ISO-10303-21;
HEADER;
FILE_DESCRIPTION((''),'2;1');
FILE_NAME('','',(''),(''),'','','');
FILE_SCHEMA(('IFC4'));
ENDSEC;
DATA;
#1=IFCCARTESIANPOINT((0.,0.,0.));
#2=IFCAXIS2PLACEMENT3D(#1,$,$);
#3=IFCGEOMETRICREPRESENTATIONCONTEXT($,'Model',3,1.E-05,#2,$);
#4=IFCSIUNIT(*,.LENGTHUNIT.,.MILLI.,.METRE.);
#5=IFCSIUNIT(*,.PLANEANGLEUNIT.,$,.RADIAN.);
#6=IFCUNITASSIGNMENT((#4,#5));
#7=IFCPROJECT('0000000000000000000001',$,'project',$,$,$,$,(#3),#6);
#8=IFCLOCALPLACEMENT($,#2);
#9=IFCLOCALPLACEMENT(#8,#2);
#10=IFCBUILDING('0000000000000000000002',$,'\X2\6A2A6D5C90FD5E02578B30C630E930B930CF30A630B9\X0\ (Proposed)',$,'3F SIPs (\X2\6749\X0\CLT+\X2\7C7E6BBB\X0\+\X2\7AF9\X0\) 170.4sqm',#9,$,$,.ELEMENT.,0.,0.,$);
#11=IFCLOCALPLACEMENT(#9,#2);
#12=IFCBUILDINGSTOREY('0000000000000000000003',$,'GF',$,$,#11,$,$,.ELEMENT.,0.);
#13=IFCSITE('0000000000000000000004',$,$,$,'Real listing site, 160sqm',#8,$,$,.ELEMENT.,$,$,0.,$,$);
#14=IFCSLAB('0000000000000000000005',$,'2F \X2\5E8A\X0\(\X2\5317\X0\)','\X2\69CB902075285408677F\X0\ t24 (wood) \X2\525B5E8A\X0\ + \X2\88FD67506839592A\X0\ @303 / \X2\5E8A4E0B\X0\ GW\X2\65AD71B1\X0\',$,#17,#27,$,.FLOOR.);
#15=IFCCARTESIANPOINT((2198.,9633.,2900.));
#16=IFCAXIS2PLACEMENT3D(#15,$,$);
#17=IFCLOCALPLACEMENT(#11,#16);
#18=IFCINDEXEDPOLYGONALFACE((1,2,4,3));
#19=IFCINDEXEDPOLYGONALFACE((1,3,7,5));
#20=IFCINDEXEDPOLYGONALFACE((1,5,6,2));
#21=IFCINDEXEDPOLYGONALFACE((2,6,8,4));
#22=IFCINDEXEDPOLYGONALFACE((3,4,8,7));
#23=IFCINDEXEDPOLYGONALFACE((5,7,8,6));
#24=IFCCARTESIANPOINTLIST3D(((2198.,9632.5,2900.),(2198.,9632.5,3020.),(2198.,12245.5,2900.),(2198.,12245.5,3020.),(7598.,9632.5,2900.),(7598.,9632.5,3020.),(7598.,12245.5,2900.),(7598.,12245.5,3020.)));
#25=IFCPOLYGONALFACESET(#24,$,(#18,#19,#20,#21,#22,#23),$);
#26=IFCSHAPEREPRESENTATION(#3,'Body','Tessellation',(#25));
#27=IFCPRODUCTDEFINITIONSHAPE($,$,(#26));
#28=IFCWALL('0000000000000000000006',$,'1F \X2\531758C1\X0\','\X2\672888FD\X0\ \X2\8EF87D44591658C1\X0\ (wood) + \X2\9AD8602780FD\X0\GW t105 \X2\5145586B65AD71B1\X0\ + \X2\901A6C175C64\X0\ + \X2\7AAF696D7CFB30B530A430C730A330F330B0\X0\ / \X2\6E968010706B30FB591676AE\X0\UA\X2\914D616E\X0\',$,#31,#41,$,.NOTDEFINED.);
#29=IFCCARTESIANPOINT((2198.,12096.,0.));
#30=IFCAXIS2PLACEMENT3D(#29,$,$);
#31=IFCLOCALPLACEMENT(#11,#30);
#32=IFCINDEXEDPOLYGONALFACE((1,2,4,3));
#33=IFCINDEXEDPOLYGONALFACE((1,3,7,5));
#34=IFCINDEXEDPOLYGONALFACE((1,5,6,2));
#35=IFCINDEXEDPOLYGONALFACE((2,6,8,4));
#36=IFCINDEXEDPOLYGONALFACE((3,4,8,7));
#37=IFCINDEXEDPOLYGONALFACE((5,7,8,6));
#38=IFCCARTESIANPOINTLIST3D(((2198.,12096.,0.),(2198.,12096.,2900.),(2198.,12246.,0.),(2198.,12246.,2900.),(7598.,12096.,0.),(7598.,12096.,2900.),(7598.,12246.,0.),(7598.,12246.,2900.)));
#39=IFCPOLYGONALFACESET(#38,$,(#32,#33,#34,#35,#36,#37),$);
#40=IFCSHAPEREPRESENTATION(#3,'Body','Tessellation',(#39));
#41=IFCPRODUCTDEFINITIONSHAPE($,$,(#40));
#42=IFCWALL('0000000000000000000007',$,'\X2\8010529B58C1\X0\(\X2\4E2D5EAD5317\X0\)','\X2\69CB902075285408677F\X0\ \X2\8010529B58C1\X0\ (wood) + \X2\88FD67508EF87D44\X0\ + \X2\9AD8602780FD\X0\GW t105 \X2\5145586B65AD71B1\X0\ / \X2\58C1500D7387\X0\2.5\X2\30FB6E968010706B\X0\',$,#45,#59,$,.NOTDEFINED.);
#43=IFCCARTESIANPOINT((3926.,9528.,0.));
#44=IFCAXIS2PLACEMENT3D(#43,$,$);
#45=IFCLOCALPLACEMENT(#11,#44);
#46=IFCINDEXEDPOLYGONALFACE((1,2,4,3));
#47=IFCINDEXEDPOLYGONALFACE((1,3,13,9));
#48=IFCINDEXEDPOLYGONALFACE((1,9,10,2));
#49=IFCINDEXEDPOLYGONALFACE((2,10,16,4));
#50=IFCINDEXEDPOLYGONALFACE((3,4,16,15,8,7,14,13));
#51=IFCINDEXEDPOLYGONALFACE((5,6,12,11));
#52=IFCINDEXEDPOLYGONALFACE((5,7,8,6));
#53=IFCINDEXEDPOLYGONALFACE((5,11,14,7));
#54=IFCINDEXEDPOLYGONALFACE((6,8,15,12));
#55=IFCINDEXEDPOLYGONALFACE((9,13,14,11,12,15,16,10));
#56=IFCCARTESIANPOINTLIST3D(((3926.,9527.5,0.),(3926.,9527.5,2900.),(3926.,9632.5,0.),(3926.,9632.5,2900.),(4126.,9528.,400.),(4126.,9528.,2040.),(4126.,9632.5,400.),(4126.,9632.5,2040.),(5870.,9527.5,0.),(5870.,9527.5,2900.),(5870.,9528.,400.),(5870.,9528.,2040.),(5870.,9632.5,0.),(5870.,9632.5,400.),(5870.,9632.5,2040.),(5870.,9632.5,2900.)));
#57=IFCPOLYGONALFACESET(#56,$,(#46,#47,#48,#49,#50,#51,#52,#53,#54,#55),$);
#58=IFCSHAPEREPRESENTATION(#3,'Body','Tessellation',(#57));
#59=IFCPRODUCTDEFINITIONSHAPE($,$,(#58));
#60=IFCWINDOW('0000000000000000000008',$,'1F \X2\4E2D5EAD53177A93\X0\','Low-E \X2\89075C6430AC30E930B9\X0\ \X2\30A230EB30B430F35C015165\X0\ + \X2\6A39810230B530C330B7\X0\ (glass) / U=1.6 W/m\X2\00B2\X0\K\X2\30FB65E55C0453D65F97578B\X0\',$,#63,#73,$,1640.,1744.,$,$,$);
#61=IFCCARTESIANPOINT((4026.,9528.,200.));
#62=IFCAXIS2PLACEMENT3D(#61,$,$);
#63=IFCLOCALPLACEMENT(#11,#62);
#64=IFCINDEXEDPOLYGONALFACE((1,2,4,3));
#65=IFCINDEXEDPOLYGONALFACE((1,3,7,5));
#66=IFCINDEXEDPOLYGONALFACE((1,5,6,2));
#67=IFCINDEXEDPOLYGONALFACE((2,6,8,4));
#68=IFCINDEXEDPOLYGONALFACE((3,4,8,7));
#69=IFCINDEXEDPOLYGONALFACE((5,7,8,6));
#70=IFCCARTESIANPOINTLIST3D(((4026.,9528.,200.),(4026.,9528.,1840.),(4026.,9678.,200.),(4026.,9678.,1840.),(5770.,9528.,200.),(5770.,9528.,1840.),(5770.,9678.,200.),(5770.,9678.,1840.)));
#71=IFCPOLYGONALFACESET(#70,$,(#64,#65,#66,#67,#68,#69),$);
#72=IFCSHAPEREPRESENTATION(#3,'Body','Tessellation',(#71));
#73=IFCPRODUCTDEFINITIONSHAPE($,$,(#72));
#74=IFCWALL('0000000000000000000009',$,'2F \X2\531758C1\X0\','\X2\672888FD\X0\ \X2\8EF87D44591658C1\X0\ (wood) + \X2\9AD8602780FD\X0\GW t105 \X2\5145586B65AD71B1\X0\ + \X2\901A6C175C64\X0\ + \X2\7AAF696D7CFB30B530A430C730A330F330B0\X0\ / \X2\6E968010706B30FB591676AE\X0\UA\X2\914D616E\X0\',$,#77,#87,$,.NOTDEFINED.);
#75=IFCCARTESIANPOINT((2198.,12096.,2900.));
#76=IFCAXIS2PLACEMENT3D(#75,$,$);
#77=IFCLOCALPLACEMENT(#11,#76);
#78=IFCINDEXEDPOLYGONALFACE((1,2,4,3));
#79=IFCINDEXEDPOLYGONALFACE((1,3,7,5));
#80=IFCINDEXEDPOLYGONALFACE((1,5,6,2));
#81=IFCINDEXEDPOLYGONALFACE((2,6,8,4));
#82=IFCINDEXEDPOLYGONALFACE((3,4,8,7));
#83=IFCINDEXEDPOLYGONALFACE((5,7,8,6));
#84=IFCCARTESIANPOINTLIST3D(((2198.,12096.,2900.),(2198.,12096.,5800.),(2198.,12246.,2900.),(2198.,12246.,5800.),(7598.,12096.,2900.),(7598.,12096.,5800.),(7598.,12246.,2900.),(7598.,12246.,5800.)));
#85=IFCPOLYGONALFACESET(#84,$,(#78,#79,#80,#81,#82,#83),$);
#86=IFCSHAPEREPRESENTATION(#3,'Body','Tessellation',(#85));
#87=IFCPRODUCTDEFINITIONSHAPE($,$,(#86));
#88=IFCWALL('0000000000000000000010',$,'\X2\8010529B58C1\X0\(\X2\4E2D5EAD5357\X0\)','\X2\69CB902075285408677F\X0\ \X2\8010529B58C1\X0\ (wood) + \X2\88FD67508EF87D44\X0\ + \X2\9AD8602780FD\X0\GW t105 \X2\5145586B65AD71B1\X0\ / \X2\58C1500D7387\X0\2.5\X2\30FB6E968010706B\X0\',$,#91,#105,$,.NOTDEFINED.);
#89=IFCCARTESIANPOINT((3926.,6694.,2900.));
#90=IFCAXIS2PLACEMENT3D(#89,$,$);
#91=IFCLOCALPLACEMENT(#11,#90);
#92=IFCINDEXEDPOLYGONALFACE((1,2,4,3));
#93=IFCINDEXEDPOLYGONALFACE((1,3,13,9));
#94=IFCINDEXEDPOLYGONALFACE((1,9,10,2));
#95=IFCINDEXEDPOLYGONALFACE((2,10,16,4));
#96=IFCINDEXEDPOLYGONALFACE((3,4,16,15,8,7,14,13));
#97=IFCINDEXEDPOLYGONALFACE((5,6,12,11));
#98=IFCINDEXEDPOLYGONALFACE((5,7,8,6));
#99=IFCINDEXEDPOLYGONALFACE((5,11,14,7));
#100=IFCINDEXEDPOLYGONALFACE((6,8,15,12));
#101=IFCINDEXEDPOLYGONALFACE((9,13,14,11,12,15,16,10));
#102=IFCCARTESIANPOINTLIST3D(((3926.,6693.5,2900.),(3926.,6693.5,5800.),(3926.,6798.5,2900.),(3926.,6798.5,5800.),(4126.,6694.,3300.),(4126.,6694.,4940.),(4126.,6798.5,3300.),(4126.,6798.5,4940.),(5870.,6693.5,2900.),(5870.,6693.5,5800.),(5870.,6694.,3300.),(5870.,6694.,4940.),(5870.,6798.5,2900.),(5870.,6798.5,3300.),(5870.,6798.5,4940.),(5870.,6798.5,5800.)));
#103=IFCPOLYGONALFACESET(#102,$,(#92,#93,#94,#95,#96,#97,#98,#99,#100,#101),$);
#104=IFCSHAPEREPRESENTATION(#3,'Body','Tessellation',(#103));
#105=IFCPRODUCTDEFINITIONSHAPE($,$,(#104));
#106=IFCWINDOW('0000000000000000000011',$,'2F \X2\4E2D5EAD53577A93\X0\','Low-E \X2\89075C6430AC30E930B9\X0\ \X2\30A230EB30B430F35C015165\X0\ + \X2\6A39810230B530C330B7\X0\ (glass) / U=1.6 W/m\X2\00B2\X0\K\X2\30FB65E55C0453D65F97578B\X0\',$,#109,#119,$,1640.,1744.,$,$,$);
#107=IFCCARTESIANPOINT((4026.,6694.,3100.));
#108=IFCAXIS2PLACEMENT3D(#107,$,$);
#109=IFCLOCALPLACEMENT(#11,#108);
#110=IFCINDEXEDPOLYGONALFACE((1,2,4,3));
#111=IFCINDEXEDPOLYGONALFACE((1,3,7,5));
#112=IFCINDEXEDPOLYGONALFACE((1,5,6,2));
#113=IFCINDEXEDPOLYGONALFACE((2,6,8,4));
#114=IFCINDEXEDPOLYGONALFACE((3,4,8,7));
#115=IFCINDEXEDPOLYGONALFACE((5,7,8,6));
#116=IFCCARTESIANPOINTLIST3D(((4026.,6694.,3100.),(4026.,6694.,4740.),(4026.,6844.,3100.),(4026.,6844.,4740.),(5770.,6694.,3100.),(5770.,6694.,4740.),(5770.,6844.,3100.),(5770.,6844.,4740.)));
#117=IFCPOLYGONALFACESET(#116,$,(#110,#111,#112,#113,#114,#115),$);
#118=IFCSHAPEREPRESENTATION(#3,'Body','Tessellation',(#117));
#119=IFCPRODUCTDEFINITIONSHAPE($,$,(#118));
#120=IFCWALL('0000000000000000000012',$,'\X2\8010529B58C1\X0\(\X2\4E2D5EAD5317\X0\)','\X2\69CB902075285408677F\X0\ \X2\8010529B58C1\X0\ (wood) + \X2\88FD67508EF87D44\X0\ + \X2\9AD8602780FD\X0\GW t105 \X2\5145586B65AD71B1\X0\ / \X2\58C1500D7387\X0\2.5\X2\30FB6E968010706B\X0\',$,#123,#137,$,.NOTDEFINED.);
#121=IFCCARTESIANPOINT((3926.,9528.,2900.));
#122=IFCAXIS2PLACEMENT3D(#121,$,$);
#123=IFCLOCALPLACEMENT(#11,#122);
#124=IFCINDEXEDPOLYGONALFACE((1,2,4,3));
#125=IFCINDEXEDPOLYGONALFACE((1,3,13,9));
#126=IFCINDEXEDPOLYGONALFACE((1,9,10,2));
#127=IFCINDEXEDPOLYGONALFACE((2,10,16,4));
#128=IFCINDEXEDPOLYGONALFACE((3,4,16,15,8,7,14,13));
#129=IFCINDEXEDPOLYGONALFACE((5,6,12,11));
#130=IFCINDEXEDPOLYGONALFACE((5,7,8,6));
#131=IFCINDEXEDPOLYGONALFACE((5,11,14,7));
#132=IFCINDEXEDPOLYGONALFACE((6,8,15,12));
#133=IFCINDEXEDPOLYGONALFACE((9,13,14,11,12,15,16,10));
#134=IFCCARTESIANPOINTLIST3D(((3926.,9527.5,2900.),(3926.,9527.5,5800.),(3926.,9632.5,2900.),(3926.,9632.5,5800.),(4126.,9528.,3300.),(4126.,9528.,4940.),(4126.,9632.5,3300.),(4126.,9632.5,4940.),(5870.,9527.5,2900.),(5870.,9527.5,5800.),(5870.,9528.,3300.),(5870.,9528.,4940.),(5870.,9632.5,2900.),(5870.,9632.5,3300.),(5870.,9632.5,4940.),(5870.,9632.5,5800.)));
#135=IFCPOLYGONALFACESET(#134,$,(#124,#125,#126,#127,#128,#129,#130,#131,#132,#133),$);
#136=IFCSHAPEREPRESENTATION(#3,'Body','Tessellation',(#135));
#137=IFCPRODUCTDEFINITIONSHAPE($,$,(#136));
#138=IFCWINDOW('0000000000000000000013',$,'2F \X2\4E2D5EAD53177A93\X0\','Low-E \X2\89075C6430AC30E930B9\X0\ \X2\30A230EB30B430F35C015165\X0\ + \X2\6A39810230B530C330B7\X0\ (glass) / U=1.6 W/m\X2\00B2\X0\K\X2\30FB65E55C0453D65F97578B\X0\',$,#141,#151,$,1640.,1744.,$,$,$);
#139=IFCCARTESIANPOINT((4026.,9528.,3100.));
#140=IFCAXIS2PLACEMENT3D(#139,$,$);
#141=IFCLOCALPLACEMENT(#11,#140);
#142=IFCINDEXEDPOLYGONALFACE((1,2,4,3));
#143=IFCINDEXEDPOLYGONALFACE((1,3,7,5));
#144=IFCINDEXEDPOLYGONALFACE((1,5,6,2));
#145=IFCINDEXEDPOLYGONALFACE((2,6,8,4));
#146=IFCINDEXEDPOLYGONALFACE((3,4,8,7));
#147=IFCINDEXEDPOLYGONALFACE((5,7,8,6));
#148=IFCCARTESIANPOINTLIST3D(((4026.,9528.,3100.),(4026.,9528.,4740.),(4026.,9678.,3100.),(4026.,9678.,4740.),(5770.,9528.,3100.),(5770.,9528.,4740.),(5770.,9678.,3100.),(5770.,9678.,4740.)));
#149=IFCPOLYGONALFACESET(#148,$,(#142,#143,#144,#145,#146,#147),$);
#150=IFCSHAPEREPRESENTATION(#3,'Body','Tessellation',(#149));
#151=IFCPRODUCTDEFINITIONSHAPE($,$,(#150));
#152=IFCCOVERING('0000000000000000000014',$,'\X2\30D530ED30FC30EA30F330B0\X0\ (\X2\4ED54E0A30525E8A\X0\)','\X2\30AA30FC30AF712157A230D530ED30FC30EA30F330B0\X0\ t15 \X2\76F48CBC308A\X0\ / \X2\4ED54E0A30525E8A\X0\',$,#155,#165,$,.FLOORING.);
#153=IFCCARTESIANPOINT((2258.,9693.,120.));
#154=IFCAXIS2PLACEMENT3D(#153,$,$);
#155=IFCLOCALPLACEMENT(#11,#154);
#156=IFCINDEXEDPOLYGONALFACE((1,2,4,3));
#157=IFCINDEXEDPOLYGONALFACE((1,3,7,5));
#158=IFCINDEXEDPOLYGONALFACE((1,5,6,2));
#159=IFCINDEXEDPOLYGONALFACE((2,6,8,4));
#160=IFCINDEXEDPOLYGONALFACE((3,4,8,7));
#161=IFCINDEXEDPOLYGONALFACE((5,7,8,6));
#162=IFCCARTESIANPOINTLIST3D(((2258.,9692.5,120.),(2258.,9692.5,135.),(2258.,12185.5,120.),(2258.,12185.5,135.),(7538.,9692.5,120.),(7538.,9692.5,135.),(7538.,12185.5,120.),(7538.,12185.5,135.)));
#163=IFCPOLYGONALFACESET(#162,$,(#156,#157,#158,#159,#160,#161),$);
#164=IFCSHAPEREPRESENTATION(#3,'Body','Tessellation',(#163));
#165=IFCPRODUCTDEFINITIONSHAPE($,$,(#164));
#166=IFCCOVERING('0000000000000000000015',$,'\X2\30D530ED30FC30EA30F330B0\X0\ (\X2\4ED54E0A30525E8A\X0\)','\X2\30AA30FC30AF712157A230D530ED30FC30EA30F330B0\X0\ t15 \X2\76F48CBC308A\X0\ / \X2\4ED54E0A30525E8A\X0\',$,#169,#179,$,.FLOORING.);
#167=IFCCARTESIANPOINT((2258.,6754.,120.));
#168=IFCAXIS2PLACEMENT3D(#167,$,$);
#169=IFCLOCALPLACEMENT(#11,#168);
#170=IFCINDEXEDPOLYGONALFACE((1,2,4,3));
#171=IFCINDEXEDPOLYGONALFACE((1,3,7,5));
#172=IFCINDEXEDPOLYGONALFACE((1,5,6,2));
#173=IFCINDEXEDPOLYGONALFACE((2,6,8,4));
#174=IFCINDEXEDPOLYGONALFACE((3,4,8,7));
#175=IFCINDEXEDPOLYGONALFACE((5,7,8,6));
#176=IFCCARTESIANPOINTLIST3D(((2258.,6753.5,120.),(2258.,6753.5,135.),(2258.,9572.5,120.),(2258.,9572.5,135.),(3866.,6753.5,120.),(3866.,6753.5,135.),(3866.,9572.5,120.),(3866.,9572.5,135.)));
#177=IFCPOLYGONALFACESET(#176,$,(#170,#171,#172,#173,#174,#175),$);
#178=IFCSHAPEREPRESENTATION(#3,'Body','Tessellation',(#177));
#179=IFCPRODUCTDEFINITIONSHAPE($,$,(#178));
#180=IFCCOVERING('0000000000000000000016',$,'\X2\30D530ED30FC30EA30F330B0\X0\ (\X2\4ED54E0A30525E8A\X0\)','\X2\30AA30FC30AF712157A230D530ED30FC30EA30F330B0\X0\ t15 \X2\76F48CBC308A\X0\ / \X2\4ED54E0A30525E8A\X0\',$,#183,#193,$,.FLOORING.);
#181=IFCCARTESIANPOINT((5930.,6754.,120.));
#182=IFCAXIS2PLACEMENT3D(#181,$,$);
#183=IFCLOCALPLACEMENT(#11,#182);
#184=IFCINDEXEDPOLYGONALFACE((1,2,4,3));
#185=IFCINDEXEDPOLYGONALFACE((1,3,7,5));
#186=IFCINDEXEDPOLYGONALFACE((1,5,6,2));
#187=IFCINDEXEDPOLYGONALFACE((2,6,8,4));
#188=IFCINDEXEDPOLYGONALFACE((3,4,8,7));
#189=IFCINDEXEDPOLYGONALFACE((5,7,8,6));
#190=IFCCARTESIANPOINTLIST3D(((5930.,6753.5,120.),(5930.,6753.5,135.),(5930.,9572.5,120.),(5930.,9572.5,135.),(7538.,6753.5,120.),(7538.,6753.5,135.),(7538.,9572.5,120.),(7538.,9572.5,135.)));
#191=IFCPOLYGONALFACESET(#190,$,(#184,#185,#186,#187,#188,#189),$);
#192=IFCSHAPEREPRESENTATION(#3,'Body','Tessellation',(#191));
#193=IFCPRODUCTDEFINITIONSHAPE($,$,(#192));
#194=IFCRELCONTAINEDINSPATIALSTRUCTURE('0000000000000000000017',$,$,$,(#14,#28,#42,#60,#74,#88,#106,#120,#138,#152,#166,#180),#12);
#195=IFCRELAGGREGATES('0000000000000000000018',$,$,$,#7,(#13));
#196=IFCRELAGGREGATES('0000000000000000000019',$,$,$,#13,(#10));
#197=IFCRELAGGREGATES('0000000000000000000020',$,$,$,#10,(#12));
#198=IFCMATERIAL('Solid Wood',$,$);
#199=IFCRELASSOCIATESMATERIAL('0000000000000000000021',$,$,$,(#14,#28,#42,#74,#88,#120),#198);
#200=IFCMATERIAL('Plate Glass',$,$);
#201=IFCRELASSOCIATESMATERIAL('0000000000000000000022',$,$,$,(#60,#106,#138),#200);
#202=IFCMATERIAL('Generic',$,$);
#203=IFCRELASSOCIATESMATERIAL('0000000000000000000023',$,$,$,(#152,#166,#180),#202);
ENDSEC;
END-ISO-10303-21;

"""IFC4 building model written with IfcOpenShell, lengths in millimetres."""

from ifc_helpers import new_model, si_unit, frame, frame_2d, origin, place, context, project, spatial, rectangle, extrude, material, element, fill, save


model = new_model("IFC4")

# Units and contexts
model_context = context("Model", 3, precision=1e-05, world=origin())
ifc_project = project(units=[si_unit("LENGTHUNIT", "METRE", prefix="MILLI"), si_unit("PLANEANGLEUNIT", "RADIAN")], contexts=[model_context])

# Site, building, storey
site_placement = place(None, origin())
site = spatial("IfcSite", under=ifc_project, at=site_placement, ObjectType="Real listing site, 160sqm", CompositionType="ELEMENT", RefElevation=0.0)
building_placement = place(site_placement, origin())
building = spatial("IfcBuilding", under=site, at=building_placement, Name="横浜都市型テラスハウス (Proposed)", ObjectType="3F SIPs (杉CLT+籾殻+竹) 170.4sqm", CompositionType="ELEMENT", ElevationOfRefHeight=0.0, ElevationOfTerrain=0.0)
storey_placement = place(building_placement, origin())
storey = spatial("IfcBuildingStorey", under=building, at=storey_placement, Name="GF", CompositionType="ELEMENT", Elevation=0.0)

# Slab
ifc_material_1 = material(Name="Solid Wood")
slab_1_placement = place(storey_placement, frame((2198.0, 9633.0, 2900.0)))
element("IfcSlab", 1, at=slab_1_placement, inside=storey, material=ifc_material_1, Name="2F 床(北)", Description="構造用合板 t24 (wood) 剛床 + 製材根太 @303 / 床下 GW断熱", PredefinedType="FLOOR", context=model_context, shape_type="SweptSolid", body=[
    extrude(rectangle(XDim=5400.0, YDim=2613.0, at=frame_2d((2700.0, 1306.0))), frame((2198.0, 9633.0, 2900.0)), (0.0, 0.0, 1.0), 120.0),
])

# Wall
wall_1_placement = place(storey_placement, frame((2198.0, 12096.0, 0.0)))
element("IfcWall", 2, at=wall_1_placement, inside=storey, material=ifc_material_1, Name="1F 北壁", Description="木製 軸組外壁 (wood) + 高性能GW t105 充填断熱 + 通気層 + 窯業系サイディング / 準耐火・外皮UA配慮", PredefinedType="NOTDEFINED", context=model_context, shape_type="SweptSolid", body=[
    extrude(rectangle(XDim=5400.0, YDim=150.0, at=frame_2d((2700.0, 75.0))), frame((2198.0, 12096.0, 0.0)), (0.0, 0.0, 1.0), 2900.0),
])

# Wall, opening, window
wall_2_placement = place(storey_placement, frame((3926.0, 9528.0, 0.0)))
wall_2 = element("IfcWall", 3, at=wall_2_placement, inside=storey, material=ifc_material_1, Name="耐力壁(中庭北)", Description="構造用合板 耐力壁 (wood) + 製材軸組 + 高性能GW t105 充填断熱 / 壁倍率2.5・準耐火", PredefinedType="NOTDEFINED", context=model_context, shape_type="SweptSolid", body=[
    extrude(rectangle(XDim=1944.0, YDim=105.0, at=frame_2d((972.0, 52.0))), frame((3926.0, 9528.0, 0.0)), (0.0, 0.0, 1.0), 2900.0),
])
opening_1_placement = place(storey_placement, frame((4026.0, 9528.0, 200.0)))
opening_1 = element("IfcOpeningElement", 4, at=opening_1_placement, cuts=wall_2, PredefinedType="NOTDEFINED", context=model_context, shape_type="SweptSolid", body=[
    extrude(rectangle(XDim=1744.0, YDim=150.0, at=frame_2d((872.0, 75.0))), frame((4026.0, 9528.0, 200.0)), (0.0, 0.0, 1.0), 1640.0),
])
ifc_material_2 = material(Name="Plate Glass")
window_1_placement = place(storey_placement, frame((4026.0, 9528.0, 200.0)))
window_1 = element("IfcWindow", 5, at=window_1_placement, inside=storey, material=ifc_material_2, Name="1F 中庭北窓", Description="Low-E 複層ガラス アルゴン封入 + 樹脂サッシ (glass) / U=1.6 W/m²K・日射取得型", OverallHeight=1640.0, OverallWidth=1744.0, context=model_context, shape_type="SweptSolid", body=[
    extrude(rectangle(XDim=1744.0, YDim=150.0, at=frame_2d((872.0, 75.0))), frame((4026.0, 9528.0, 200.0)), (0.0, 0.0, 1.0), 1640.0),
])
fill(opening_1, window_1)

# Wall
wall_3_placement = place(storey_placement, frame((2198.0, 12096.0, 2900.0)))
element("IfcWall", 6, at=wall_3_placement, inside=storey, material=ifc_material_1, Name="2F 北壁", Description="木製 軸組外壁 (wood) + 高性能GW t105 充填断熱 + 通気層 + 窯業系サイディング / 準耐火・外皮UA配慮", PredefinedType="NOTDEFINED", context=model_context, shape_type="SweptSolid", body=[
    extrude(rectangle(XDim=5400.0, YDim=150.0, at=frame_2d((2700.0, 75.0))), frame((2198.0, 12096.0, 2900.0)), (0.0, 0.0, 1.0), 2900.0),
])

# Walls, openings, windows
wall_4_placement = place(storey_placement, frame((3926.0, 6694.0, 2900.0)))
wall_4 = element("IfcWall", 7, at=wall_4_placement, inside=storey, material=ifc_material_1, Name="耐力壁(中庭南)", Description="構造用合板 耐力壁 (wood) + 製材軸組 + 高性能GW t105 充填断熱 / 壁倍率2.5・準耐火", PredefinedType="NOTDEFINED", context=model_context, shape_type="SweptSolid", body=[
    extrude(rectangle(XDim=1944.0, YDim=105.0, at=frame_2d((972.0, 52.0))), frame((3926.0, 6694.0, 2900.0)), (0.0, 0.0, 1.0), 2900.0),
])
opening_2_placement = place(storey_placement, frame((4026.0, 6694.0, 3100.0)))
opening_2 = element("IfcOpeningElement", 8, at=opening_2_placement, cuts=wall_4, PredefinedType="NOTDEFINED", context=model_context, shape_type="SweptSolid", body=[
    extrude(rectangle(XDim=1744.0, YDim=150.0, at=frame_2d((872.0, 75.0))), frame((4026.0, 6694.0, 3100.0)), (0.0, 0.0, 1.0), 1640.0),
])
window_2_placement = place(storey_placement, frame((4026.0, 6694.0, 3100.0)))
window_2 = element("IfcWindow", 9, at=window_2_placement, inside=storey, material=ifc_material_2, Name="2F 中庭南窓", Description="Low-E 複層ガラス アルゴン封入 + 樹脂サッシ (glass) / U=1.6 W/m²K・日射取得型", OverallHeight=1640.0, OverallWidth=1744.0, context=model_context, shape_type="SweptSolid", body=[
    extrude(rectangle(XDim=1744.0, YDim=150.0, at=frame_2d((872.0, 75.0))), frame((4026.0, 6694.0, 3100.0)), (0.0, 0.0, 1.0), 1640.0),
])
fill(opening_2, window_2)
wall_5_placement = place(storey_placement, frame((3926.0, 9528.0, 2900.0)))
wall_5 = element("IfcWall", 10, at=wall_5_placement, inside=storey, material=ifc_material_1, Name="耐力壁(中庭北)", Description="構造用合板 耐力壁 (wood) + 製材軸組 + 高性能GW t105 充填断熱 / 壁倍率2.5・準耐火", PredefinedType="NOTDEFINED", context=model_context, shape_type="SweptSolid", body=[
    extrude(rectangle(XDim=1944.0, YDim=105.0, at=frame_2d((972.0, 52.0))), frame((3926.0, 9528.0, 2900.0)), (0.0, 0.0, 1.0), 2900.0),
])
opening_3_placement = place(storey_placement, frame((4026.0, 9528.0, 3100.0)))
opening_3 = element("IfcOpeningElement", 11, at=opening_3_placement, cuts=wall_5, PredefinedType="NOTDEFINED", context=model_context, shape_type="SweptSolid", body=[
    extrude(rectangle(XDim=1744.0, YDim=150.0, at=frame_2d((872.0, 75.0))), frame((4026.0, 9528.0, 3100.0)), (0.0, 0.0, 1.0), 1640.0),
])
window_3_placement = place(storey_placement, frame((4026.0, 9528.0, 3100.0)))
window_3 = element("IfcWindow", 12, at=window_3_placement, inside=storey, material=ifc_material_2, Name="2F 中庭北窓", Description="Low-E 複層ガラス アルゴン封入 + 樹脂サッシ (glass) / U=1.6 W/m²K・日射取得型", OverallHeight=1640.0, OverallWidth=1744.0, context=model_context, shape_type="SweptSolid", body=[
    extrude(rectangle(XDim=1744.0, YDim=150.0, at=frame_2d((872.0, 75.0))), frame((4026.0, 9528.0, 3100.0)), (0.0, 0.0, 1.0), 1640.0),
])
fill(opening_3, window_3)

# Coverings
ifc_material_3 = material(Name="Generic")
covering_1_placement = place(storey_placement, frame((2258.0, 9693.0, 120.0)))
element("IfcCovering", 13, at=covering_1_placement, inside=storey, material=ifc_material_3, Name="フローリング (仕上げ床)", Description="オーク無垢フローリング t15 直貼り / 仕上げ床", PredefinedType="FLOORING", context=model_context, shape_type="SweptSolid", body=[
    extrude(rectangle(XDim=5280.0, YDim=2493.0, at=frame_2d((2640.0, 1246.0))), frame((2258.0, 9693.0, 120.0)), (0.0, 0.0, 1.0), 15.0),
])
covering_2_placement = place(storey_placement, frame((2258.0, 6754.0, 120.0)))
element("IfcCovering", 14, at=covering_2_placement, inside=storey, material=ifc_material_3, Name="フローリング (仕上げ床)", Description="オーク無垢フローリング t15 直貼り / 仕上げ床", PredefinedType="FLOORING", context=model_context, shape_type="SweptSolid", body=[
    extrude(rectangle(XDim=1608.0, YDim=2819.0, at=frame_2d((804.0, 1409.0))), frame((2258.0, 6754.0, 120.0)), (0.0, 0.0, 1.0), 15.0),
])
covering_3_placement = place(storey_placement, frame((5930.0, 6754.0, 120.0)))
element("IfcCovering", 15, at=covering_3_placement, inside=storey, material=ifc_material_3, Name="フローリング (仕上げ床)", Description="オーク無垢フローリング t15 直貼り / 仕上げ床", PredefinedType="FLOORING", context=model_context, shape_type="SweptSolid", body=[
    extrude(rectangle(XDim=1608.0, YDim=2819.0, at=frame_2d((804.0, 1409.0))), frame((5930.0, 6754.0, 120.0)), (0.0, 0.0, 1.0), 15.0),
])

save(model, "model.ifc")
